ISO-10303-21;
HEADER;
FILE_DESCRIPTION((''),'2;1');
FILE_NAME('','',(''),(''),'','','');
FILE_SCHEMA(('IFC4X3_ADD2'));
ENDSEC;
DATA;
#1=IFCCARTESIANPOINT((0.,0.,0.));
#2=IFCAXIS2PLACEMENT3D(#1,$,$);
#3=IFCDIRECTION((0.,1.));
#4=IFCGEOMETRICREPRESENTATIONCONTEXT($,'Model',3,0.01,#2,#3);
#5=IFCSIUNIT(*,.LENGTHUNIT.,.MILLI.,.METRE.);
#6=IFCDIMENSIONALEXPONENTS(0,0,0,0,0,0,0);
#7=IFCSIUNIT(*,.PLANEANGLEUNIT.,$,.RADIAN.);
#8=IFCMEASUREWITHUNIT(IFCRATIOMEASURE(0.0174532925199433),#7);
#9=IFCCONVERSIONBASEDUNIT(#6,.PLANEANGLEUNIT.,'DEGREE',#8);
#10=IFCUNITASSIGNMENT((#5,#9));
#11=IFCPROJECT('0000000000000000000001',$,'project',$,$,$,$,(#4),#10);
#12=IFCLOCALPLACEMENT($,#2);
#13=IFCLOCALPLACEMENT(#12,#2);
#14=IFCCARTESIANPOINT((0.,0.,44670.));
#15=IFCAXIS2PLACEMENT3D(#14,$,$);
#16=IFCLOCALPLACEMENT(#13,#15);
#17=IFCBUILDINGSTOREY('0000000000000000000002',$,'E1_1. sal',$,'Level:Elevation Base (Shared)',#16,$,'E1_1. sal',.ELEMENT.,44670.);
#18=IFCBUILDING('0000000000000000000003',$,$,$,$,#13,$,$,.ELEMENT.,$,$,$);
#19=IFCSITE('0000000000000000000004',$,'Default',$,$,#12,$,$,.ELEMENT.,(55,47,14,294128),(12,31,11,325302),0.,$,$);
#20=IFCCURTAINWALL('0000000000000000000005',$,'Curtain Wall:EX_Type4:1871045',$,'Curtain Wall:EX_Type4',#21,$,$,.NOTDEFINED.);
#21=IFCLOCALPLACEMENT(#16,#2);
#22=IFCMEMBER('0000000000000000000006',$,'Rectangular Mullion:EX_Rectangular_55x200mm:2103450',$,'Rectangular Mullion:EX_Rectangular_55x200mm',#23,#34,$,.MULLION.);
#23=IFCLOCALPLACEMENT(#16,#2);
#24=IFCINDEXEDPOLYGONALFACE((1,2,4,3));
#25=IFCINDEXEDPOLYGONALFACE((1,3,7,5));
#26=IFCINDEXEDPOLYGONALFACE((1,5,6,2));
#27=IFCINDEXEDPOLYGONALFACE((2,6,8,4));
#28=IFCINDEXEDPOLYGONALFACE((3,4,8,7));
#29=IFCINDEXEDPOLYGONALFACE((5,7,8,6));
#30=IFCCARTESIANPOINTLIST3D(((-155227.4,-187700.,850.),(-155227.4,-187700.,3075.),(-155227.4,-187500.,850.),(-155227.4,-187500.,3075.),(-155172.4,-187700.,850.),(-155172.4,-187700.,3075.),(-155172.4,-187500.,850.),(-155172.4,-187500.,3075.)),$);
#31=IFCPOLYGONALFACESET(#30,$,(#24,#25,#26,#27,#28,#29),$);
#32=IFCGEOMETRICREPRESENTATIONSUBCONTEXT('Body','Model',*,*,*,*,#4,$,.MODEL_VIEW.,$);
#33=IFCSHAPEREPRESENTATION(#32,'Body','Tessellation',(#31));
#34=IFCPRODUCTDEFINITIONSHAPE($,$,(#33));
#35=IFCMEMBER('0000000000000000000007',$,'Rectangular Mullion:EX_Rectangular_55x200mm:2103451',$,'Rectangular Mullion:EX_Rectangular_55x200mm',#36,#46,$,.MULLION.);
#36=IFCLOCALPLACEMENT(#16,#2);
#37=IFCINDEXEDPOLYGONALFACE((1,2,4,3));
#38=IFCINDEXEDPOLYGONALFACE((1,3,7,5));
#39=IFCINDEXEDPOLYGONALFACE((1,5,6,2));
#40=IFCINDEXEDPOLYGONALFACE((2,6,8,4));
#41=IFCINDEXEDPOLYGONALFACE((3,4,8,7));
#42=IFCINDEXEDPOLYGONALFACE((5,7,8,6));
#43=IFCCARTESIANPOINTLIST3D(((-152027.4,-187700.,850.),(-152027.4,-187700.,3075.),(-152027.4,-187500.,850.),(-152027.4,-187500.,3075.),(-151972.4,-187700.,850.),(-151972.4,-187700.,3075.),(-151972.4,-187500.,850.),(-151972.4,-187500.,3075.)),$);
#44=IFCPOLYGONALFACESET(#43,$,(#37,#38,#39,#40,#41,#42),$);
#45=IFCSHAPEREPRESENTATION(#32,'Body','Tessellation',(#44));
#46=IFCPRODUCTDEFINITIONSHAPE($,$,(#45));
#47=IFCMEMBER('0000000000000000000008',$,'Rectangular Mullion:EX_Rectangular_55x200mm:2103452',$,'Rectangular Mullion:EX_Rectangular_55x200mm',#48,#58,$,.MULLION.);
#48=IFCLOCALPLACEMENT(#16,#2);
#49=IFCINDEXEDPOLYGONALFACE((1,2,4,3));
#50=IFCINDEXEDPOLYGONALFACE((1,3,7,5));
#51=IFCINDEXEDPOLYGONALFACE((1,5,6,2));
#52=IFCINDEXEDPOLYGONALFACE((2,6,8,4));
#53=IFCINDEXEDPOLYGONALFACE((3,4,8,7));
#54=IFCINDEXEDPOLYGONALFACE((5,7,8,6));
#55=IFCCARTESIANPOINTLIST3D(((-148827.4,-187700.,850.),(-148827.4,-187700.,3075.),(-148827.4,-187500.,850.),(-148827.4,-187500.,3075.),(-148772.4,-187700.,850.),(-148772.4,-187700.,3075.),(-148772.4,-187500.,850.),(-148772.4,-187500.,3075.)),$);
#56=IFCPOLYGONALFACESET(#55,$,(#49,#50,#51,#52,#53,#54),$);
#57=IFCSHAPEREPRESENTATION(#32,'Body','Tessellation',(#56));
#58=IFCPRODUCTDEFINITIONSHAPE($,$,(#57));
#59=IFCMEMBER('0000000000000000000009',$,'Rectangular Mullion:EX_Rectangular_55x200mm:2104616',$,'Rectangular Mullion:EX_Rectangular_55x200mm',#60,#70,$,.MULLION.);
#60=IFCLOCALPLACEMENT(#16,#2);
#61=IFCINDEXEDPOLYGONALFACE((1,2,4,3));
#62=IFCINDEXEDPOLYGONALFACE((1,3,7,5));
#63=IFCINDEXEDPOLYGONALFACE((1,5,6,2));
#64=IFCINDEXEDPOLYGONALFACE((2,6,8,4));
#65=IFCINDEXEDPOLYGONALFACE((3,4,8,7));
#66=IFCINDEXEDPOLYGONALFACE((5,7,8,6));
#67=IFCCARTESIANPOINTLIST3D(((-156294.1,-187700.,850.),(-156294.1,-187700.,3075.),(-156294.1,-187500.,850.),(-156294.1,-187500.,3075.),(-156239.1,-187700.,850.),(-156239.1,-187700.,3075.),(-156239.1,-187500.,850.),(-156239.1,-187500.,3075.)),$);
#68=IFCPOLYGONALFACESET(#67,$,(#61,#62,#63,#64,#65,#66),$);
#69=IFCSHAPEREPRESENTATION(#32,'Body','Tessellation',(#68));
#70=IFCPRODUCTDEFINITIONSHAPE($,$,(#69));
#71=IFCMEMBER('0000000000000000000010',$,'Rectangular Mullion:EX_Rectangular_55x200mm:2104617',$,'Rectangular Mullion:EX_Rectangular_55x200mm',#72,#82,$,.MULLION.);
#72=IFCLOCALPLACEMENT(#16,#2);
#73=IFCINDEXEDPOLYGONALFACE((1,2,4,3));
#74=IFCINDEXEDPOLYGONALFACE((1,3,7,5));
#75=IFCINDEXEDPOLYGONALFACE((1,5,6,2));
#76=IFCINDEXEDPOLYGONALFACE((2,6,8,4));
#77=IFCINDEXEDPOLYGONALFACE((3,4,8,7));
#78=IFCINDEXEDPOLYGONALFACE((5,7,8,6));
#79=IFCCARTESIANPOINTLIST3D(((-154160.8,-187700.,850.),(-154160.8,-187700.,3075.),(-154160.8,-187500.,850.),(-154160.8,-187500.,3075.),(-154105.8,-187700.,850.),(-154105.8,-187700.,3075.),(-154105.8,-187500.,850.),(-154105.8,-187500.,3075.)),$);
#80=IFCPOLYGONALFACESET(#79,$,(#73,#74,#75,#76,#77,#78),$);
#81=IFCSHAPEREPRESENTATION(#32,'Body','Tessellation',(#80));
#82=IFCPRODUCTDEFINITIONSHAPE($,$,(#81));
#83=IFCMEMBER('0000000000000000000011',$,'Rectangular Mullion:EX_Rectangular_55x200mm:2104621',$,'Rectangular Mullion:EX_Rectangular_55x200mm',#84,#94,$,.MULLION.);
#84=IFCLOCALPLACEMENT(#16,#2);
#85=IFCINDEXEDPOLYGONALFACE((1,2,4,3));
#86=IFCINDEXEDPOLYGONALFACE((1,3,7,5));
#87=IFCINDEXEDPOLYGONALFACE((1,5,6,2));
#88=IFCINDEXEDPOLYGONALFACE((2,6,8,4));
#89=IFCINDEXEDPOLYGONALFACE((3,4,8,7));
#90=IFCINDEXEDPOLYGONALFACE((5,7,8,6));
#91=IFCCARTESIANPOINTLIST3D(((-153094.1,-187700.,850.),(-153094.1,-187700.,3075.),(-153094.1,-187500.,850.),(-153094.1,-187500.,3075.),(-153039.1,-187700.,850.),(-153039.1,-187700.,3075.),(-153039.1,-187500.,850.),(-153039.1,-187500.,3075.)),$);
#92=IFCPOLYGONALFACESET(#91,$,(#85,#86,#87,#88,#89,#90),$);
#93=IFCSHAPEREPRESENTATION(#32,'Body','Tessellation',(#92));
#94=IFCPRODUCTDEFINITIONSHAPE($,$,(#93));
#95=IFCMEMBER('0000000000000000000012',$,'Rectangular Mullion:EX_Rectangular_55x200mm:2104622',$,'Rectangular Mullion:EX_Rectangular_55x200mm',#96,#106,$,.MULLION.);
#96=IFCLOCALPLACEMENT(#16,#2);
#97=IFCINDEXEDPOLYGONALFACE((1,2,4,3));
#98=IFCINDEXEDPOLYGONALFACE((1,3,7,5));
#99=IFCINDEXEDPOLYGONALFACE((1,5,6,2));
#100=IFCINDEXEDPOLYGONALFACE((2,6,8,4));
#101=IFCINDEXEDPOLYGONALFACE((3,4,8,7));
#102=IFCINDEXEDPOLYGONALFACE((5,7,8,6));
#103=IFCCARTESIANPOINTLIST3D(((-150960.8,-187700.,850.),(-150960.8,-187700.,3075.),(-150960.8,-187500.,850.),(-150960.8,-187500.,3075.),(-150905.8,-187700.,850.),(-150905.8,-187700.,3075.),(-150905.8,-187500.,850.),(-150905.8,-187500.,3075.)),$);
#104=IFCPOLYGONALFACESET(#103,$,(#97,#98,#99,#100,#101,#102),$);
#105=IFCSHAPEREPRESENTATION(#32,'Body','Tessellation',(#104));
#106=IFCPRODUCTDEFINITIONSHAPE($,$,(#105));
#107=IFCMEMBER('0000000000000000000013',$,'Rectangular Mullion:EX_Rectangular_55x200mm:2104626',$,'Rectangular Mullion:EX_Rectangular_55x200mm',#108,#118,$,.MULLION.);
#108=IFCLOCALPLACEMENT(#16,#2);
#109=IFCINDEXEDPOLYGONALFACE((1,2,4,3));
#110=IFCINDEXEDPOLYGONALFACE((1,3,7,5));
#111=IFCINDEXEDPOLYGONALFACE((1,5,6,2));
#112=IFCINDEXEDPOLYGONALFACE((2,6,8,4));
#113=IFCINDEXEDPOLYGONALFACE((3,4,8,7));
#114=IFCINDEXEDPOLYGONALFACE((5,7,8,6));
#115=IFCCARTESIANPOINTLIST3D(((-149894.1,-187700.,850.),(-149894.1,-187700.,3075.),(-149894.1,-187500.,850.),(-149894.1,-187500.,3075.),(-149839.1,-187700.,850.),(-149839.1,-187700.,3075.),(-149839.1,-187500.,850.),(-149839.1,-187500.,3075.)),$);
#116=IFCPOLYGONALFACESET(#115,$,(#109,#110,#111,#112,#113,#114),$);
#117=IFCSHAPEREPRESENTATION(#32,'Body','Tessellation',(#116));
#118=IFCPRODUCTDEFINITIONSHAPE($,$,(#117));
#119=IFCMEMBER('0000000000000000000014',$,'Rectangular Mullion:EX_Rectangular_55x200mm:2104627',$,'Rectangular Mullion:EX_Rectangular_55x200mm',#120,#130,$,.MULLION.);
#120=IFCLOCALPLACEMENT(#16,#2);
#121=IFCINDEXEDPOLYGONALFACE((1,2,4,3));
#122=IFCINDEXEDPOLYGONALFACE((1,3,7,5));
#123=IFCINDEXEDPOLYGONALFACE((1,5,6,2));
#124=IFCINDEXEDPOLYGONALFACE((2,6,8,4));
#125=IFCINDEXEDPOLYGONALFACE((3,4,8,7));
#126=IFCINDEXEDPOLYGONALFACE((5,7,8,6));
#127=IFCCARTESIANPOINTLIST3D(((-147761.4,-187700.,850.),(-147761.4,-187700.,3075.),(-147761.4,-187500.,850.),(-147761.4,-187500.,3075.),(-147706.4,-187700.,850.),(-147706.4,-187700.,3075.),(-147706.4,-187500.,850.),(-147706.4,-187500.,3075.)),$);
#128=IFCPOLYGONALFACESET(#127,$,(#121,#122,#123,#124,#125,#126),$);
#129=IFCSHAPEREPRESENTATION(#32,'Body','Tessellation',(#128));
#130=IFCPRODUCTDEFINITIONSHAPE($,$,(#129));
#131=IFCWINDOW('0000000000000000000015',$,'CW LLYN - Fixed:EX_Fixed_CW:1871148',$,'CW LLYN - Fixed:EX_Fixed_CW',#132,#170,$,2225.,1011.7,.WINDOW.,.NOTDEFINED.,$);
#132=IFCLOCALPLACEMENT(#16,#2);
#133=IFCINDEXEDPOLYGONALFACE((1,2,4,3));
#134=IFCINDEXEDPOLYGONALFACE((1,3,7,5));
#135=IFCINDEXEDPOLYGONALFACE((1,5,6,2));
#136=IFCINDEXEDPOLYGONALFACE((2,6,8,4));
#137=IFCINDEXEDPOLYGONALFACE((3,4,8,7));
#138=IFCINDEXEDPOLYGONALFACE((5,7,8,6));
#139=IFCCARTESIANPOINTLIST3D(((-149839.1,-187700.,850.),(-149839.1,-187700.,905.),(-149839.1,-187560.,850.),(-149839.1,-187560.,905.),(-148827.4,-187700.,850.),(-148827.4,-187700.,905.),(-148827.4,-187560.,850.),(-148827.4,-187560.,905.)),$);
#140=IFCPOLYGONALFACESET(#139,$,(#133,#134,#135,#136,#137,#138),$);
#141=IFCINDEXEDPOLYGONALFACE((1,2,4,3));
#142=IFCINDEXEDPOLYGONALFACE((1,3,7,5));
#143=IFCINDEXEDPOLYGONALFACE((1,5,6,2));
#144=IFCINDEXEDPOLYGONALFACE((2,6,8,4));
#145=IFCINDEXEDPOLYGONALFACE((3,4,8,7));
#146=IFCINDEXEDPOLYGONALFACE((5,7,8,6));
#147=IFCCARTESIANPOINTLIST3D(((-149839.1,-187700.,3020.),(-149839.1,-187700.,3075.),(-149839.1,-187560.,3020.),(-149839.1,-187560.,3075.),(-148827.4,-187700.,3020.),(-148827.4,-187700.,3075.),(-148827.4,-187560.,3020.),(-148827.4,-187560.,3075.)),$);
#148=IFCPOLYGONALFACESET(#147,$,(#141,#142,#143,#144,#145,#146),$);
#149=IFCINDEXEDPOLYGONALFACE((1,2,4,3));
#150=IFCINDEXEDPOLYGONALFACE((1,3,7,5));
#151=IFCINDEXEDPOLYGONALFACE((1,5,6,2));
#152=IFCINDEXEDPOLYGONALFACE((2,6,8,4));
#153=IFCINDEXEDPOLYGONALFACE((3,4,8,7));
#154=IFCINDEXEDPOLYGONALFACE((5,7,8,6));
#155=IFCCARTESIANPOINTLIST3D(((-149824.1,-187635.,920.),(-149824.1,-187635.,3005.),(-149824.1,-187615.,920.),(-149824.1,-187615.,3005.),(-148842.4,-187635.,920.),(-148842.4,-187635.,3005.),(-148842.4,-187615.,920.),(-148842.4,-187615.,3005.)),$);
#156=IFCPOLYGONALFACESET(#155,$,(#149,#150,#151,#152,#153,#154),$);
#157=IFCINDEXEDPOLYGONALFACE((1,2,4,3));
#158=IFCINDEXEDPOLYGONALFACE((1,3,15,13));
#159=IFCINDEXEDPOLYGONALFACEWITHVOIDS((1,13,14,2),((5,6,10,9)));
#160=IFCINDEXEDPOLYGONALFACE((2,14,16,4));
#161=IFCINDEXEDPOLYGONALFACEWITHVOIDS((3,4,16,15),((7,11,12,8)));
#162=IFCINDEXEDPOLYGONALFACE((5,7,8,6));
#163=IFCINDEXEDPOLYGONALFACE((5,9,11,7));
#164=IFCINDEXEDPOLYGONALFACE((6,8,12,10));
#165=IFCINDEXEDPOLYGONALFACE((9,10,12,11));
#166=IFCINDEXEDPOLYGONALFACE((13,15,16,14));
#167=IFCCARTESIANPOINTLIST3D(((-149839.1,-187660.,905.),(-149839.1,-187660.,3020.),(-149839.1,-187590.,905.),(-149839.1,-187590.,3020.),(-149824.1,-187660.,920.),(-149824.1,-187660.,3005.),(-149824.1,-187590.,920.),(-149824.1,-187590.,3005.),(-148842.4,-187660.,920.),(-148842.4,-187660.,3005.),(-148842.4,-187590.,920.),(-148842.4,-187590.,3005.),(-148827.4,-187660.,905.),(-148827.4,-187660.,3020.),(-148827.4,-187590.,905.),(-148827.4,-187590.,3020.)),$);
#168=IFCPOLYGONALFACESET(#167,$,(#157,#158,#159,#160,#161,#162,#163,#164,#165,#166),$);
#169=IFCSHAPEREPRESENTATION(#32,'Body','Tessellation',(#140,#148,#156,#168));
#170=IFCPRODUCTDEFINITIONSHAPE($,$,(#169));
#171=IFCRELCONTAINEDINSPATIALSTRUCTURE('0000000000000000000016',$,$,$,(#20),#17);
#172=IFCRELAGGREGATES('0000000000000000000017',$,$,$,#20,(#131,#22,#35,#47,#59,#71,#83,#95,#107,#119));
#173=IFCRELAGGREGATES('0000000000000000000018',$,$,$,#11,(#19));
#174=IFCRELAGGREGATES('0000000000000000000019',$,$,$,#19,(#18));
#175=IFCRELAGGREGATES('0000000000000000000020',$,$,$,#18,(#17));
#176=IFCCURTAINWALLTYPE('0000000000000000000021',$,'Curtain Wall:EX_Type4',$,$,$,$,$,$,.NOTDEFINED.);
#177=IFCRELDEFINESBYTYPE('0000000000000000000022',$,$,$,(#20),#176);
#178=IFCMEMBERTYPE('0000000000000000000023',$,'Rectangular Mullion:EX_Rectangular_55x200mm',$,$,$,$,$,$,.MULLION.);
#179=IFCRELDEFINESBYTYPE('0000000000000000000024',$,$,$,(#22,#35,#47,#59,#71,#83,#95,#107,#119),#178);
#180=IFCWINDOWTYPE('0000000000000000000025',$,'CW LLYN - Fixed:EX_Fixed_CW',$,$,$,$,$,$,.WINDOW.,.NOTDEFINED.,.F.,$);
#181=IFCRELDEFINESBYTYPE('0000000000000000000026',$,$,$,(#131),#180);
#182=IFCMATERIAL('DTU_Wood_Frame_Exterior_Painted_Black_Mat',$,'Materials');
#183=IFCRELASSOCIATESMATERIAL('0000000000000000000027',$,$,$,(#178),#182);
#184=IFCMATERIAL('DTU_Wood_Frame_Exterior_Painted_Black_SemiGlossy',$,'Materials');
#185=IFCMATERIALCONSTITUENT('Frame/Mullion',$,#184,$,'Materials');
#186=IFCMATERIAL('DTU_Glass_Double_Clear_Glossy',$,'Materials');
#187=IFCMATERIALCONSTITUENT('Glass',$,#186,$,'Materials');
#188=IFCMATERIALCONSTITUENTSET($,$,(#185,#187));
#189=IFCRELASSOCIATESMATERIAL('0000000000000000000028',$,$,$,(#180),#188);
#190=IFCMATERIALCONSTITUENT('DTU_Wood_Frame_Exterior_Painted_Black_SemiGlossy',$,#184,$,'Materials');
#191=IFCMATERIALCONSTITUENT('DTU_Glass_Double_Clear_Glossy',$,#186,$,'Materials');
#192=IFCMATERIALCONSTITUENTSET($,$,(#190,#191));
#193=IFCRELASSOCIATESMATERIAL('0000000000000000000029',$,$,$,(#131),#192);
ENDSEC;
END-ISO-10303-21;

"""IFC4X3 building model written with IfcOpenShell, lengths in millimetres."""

from ifc_helpers import new_model, entity, si_unit, converted_unit, direction, frame, frame_2d, origin, origin_2d_with_axis, place, context, subcontext, project, spatial, polyline, rectangle, outline, extrude, source, transform, mapped, material, constituent, constituent_set, material_profile, profile_set, type_object, type_shapes, element, aggregate, save


model = new_model("IFC4X3")

# Units and contexts
model_context = context("Model", 3, precision=0.01, world=origin(), true_north=direction((0.0, 1.0)))
body_context = subcontext(model_context, "Body", "Model", "MODEL_VIEW")
ifc_project = project(units=[si_unit("LENGTHUNIT", "METRE", prefix="MILLI"), converted_unit("PLANEANGLEUNIT", "DEGREE", entity("IfcRatioMeasure", 0.0174532925199433), si_unit("PLANEANGLEUNIT", "RADIAN"), dimensions=[0, 0, 0, 0, 0, 0, 0])], contexts=[model_context])

# Site, building, storey
site_placement = place(None, origin())
site = spatial("IfcSite", under=ifc_project, at=site_placement, Name="Default", CompositionType="ELEMENT", RefLatitude=(55, 47, 14, 294128), RefLongitude=(12, 31, 11, 325302), RefElevation=0.0)
building_placement = place(site_placement, origin())
building = spatial("IfcBuilding", under=site, at=building_placement, CompositionType="ELEMENT")
storey_placement = place(building_placement, frame((0.0, 0.0, 44670.0)))
storey = spatial("IfcBuildingStorey", under=building, at=storey_placement, Name="E1_1. sal", ObjectType="Level:Elevation Base (Shared)", LongName="E1_1. sal", CompositionType="ELEMENT", Elevation=44670.0)

# Curtain wall, members, window
curtain_wall_type = type_object("IfcCurtainWallType", Name="Curtain Wall:EX_Type4", PredefinedType="NOTDEFINED")
curtain_wall_placement = place(storey_placement, frame((0.0, 0.0, -44670.0)))
curtain_wall = element("IfcCurtainWall", 1, at=curtain_wall_placement, inside=storey, type_object=curtain_wall_type, Name="Curtain Wall:EX_Type4:1871045", ObjectType="Curtain Wall:EX_Type4", PredefinedType="NOTDEFINED")
ifc_material_1 = material(Name="DTU_Wood_Frame_Exterior_Painted_Black_Mat", Category="Materials")
ifc_material_profile = material_profile(ifc_material_1, rectangle(XDim=200.0, YDim=55.0, at=origin_2d_with_axis()), Name="EX_Rectangular_55x200mm")
ifc_profile_set = profile_set([ifc_material_profile], Name="EX_Rectangular_55x200mm")
member_type = type_object("IfcMemberType", Name="Rectangular Mullion:EX_Rectangular_55x200mm", PredefinedType="MULLION", material=ifc_profile_set)
shared_shape_1 = source(origin(), body_context, "Body", "SweptSolid", [
    extrude(rectangle(XDim=200.0, YDim=55.0, at=origin_2d_with_axis()), frame((0.0, -100.0, -2225.0), z_axis=(0.0, 0.0, 1.0), x_axis=(0.0, -1.0, 0.0)), (0.0, 0.0, 1.0), 2225.0),
])
type_shapes(member_type, [shared_shape_1])
member_1_placement = place(curtain_wall_placement, frame((-155199.9, -187500.0, 45520.0), z_axis=(0.0, 0.0, -1.0), x_axis=(-1.0, 0.0, 0.0)))
member_1 = element("IfcMember", 2, at=member_1_placement, type_object=member_type, Name="Rectangular Mullion:EX_Rectangular_55x200mm:2103450", ObjectType="Rectangular Mullion:EX_Rectangular_55x200mm", PredefinedType="MULLION", context=body_context, shape_type="MappedRepresentation", body=[
    mapped(shared_shape_1, transform((0.0, 0.0, 0.0), scale=1.0)),
])
member_2_placement = place(curtain_wall_placement, frame((-151999.9, -187500.0, 45520.0), z_axis=(0.0, 0.0, -1.0), x_axis=(-1.0, 0.0, 0.0)))
member_2 = element("IfcMember", 3, at=member_2_placement, type_object=member_type, Name="Rectangular Mullion:EX_Rectangular_55x200mm:2103451", ObjectType="Rectangular Mullion:EX_Rectangular_55x200mm", PredefinedType="MULLION", context=body_context, shape_type="MappedRepresentation", body=[
    mapped(shared_shape_1, transform((0.0, 0.0, 0.0), scale=1.0)),
])
member_3_placement = place(curtain_wall_placement, frame((-148799.9, -187500.0, 45520.0), z_axis=(0.0, 0.0, -1.0), x_axis=(-1.0, 0.0, 0.0)))
member_3 = element("IfcMember", 4, at=member_3_placement, type_object=member_type, Name="Rectangular Mullion:EX_Rectangular_55x200mm:2103452", ObjectType="Rectangular Mullion:EX_Rectangular_55x200mm", PredefinedType="MULLION", context=body_context, shape_type="MappedRepresentation", body=[
    mapped(shared_shape_1, transform((0.0, 0.0, 0.0), scale=1.0)),
])
member_4_placement = place(curtain_wall_placement, frame((-156266.6, -187500.0, 45520.0), z_axis=(0.0, 0.0, -1.0), x_axis=(-1.0, 0.0, 0.0)))
member_4 = element("IfcMember", 5, at=member_4_placement, type_object=member_type, Name="Rectangular Mullion:EX_Rectangular_55x200mm:2104616", ObjectType="Rectangular Mullion:EX_Rectangular_55x200mm", PredefinedType="MULLION", context=body_context, shape_type="MappedRepresentation", body=[
    mapped(shared_shape_1, transform((0.0, 0.0, 0.0), scale=1.0)),
])
member_5_placement = place(curtain_wall_placement, frame((-154133.3, -187500.0, 45520.0), z_axis=(0.0, 0.0, -1.0), x_axis=(-1.0, 0.0, 0.0)))
member_5 = element("IfcMember", 6, at=member_5_placement, type_object=member_type, Name="Rectangular Mullion:EX_Rectangular_55x200mm:2104617", ObjectType="Rectangular Mullion:EX_Rectangular_55x200mm", PredefinedType="MULLION", context=body_context, shape_type="MappedRepresentation", body=[
    mapped(shared_shape_1, transform((0.0, 0.0, 0.0), scale=1.0)),
])
member_6_placement = place(curtain_wall_placement, frame((-153066.6, -187500.0, 45520.0), z_axis=(0.0, 0.0, -1.0), x_axis=(-1.0, 0.0, 0.0)))
member_6 = element("IfcMember", 7, at=member_6_placement, type_object=member_type, Name="Rectangular Mullion:EX_Rectangular_55x200mm:2104621", ObjectType="Rectangular Mullion:EX_Rectangular_55x200mm", PredefinedType="MULLION", context=body_context, shape_type="MappedRepresentation", body=[
    mapped(shared_shape_1, transform((0.0, 0.0, 0.0), scale=1.0)),
])
member_7_placement = place(curtain_wall_placement, frame((-150933.3, -187500.0, 45520.0), z_axis=(0.0, 0.0, -1.0), x_axis=(-1.0, 0.0, 0.0)))
member_7 = element("IfcMember", 8, at=member_7_placement, type_object=member_type, Name="Rectangular Mullion:EX_Rectangular_55x200mm:2104622", ObjectType="Rectangular Mullion:EX_Rectangular_55x200mm", PredefinedType="MULLION", context=body_context, shape_type="MappedRepresentation", body=[
    mapped(shared_shape_1, transform((0.0, 0.0, 0.0), scale=1.0)),
])
member_8_placement = place(curtain_wall_placement, frame((-149866.6, -187500.0, 45520.0), z_axis=(0.0, 0.0, -1.0), x_axis=(-1.0, 0.0, 0.0)))
member_8 = element("IfcMember", 9, at=member_8_placement, type_object=member_type, Name="Rectangular Mullion:EX_Rectangular_55x200mm:2104626", ObjectType="Rectangular Mullion:EX_Rectangular_55x200mm", PredefinedType="MULLION", context=body_context, shape_type="MappedRepresentation", body=[
    mapped(shared_shape_1, transform((0.0, 0.0, 0.0), scale=1.0)),
])
member_9_placement = place(curtain_wall_placement, frame((-147733.9, -187500.0, 45520.0), z_axis=(0.0, 0.0, -1.0), x_axis=(-1.0, 0.0, 0.0)))
member_9 = element("IfcMember", 10, at=member_9_placement, type_object=member_type, Name="Rectangular Mullion:EX_Rectangular_55x200mm:2104627", ObjectType="Rectangular Mullion:EX_Rectangular_55x200mm", PredefinedType="MULLION", context=body_context, shape_type="MappedRepresentation", body=[
    mapped(shared_shape_1, transform((0.0, 0.0, 0.0), scale=1.0)),
])
ifc_material_2 = material(Name="DTU_Wood_Frame_Exterior_Painted_Black_SemiGlossy", Category="Materials")
ifc_constituent_1 = constituent(ifc_material_2, Name="DTU_Wood_Frame_Exterior_Painted_Black_SemiGlossy", Category="Materials")
ifc_material_3 = material(Name="DTU_Glass_Double_Clear_Glossy", Category="Materials")
ifc_constituent_2 = constituent(ifc_material_3, Name="DTU_Glass_Double_Clear_Glossy", Category="Materials")
ifc_constituent_set_1 = constituent_set(constituents=[ifc_constituent_1, ifc_constituent_2])
ifc_constituent_3 = constituent(ifc_material_2, Name="Frame/Mullion", Category="Materials")
ifc_constituent_4 = constituent(ifc_material_3, Name="Glass", Category="Materials")
ifc_constituent_set_2 = constituent_set(constituents=[ifc_constituent_3, ifc_constituent_4])
window_type_1 = type_object("IfcWindowType", Name="CW LLYN - Fixed:EX_Fixed_CW", ParameterTakesPrecedence=False, PartitioningType="NOTDEFINED", PredefinedType="WINDOW", material=ifc_constituent_set_2)
shared_shape_2 = source(origin(), body_context, "Body", "SweptSolid", [
    extrude(rectangle(XDim=140.0, YDim=1011.7, at=origin_2d_with_axis()), frame((0.0, -130.0, 0.0), z_axis=(0.0, 0.0, 1.0), x_axis=(0.0, -1.0, 0.0)), (0.0, 0.0, 1.0), 55.0),
    extrude(rectangle(XDim=140.0, YDim=1011.7, at=frame_2d((0.0, 0.0), x_axis=(1.0, 0.0))), frame((0.0, -130.0, 2170.0), z_axis=(0.0, 0.0, 1.0), x_axis=(0.0, -1.0, 0.0)), (0.0, 0.0, 1.0), 55.0),
    extrude(rectangle(XDim=981.7, YDim=20.0, at=frame_2d((0.0, 0.0), x_axis=(1.0, 0.0))), frame((0.0, -125.0, 70.0), z_axis=(0.0, 0.0, 1.0), x_axis=(-1.0, 0.0, 0.0)), (0.0, 0.0, 1.0), 2085.0),
    extrude(outline(polyline([(-1057.5, -505.8), (1057.5, -505.8), (1057.5, 505.8), (-1057.5, 505.8), (-1057.5, -505.8)]), holes=[polyline([(-1042.5, 490.8), (1042.5, 490.8), (1042.5, -490.8), (-1042.5, -490.8), (-1042.5, 490.8)])]), frame((0.0, -90.0, 1112.5), z_axis=(0.0, -1.0, 0.0), x_axis=(0.0, 0.0, 1.0)), (0.0, 0.0, 1.0), 70.0),
])
type_shapes(window_type_1, [shared_shape_2])
window_1_placement = place(curtain_wall_placement, frame((-149333.3, -187500.0, 45520.0)))
window_1 = element("IfcWindow", 11, at=window_1_placement, type_object=window_type_1, material=ifc_constituent_set_1, Name="CW LLYN - Fixed:EX_Fixed_CW:1871148", ObjectType="CW LLYN - Fixed:EX_Fixed_CW", OverallHeight=2225.0, OverallWidth=1011.7, PartitioningType="NOTDEFINED", PredefinedType="WINDOW", context=body_context, shape_type="MappedRepresentation", body=[
    mapped(shared_shape_2, transform((0.0, 0.0, 0.0), scale=1.0)),
])
aggregate(curtain_wall, [window_1, member_1, member_2, member_3, member_4, member_5, member_6, member_7, member_8, member_9])

save(model, "model.ifc")
